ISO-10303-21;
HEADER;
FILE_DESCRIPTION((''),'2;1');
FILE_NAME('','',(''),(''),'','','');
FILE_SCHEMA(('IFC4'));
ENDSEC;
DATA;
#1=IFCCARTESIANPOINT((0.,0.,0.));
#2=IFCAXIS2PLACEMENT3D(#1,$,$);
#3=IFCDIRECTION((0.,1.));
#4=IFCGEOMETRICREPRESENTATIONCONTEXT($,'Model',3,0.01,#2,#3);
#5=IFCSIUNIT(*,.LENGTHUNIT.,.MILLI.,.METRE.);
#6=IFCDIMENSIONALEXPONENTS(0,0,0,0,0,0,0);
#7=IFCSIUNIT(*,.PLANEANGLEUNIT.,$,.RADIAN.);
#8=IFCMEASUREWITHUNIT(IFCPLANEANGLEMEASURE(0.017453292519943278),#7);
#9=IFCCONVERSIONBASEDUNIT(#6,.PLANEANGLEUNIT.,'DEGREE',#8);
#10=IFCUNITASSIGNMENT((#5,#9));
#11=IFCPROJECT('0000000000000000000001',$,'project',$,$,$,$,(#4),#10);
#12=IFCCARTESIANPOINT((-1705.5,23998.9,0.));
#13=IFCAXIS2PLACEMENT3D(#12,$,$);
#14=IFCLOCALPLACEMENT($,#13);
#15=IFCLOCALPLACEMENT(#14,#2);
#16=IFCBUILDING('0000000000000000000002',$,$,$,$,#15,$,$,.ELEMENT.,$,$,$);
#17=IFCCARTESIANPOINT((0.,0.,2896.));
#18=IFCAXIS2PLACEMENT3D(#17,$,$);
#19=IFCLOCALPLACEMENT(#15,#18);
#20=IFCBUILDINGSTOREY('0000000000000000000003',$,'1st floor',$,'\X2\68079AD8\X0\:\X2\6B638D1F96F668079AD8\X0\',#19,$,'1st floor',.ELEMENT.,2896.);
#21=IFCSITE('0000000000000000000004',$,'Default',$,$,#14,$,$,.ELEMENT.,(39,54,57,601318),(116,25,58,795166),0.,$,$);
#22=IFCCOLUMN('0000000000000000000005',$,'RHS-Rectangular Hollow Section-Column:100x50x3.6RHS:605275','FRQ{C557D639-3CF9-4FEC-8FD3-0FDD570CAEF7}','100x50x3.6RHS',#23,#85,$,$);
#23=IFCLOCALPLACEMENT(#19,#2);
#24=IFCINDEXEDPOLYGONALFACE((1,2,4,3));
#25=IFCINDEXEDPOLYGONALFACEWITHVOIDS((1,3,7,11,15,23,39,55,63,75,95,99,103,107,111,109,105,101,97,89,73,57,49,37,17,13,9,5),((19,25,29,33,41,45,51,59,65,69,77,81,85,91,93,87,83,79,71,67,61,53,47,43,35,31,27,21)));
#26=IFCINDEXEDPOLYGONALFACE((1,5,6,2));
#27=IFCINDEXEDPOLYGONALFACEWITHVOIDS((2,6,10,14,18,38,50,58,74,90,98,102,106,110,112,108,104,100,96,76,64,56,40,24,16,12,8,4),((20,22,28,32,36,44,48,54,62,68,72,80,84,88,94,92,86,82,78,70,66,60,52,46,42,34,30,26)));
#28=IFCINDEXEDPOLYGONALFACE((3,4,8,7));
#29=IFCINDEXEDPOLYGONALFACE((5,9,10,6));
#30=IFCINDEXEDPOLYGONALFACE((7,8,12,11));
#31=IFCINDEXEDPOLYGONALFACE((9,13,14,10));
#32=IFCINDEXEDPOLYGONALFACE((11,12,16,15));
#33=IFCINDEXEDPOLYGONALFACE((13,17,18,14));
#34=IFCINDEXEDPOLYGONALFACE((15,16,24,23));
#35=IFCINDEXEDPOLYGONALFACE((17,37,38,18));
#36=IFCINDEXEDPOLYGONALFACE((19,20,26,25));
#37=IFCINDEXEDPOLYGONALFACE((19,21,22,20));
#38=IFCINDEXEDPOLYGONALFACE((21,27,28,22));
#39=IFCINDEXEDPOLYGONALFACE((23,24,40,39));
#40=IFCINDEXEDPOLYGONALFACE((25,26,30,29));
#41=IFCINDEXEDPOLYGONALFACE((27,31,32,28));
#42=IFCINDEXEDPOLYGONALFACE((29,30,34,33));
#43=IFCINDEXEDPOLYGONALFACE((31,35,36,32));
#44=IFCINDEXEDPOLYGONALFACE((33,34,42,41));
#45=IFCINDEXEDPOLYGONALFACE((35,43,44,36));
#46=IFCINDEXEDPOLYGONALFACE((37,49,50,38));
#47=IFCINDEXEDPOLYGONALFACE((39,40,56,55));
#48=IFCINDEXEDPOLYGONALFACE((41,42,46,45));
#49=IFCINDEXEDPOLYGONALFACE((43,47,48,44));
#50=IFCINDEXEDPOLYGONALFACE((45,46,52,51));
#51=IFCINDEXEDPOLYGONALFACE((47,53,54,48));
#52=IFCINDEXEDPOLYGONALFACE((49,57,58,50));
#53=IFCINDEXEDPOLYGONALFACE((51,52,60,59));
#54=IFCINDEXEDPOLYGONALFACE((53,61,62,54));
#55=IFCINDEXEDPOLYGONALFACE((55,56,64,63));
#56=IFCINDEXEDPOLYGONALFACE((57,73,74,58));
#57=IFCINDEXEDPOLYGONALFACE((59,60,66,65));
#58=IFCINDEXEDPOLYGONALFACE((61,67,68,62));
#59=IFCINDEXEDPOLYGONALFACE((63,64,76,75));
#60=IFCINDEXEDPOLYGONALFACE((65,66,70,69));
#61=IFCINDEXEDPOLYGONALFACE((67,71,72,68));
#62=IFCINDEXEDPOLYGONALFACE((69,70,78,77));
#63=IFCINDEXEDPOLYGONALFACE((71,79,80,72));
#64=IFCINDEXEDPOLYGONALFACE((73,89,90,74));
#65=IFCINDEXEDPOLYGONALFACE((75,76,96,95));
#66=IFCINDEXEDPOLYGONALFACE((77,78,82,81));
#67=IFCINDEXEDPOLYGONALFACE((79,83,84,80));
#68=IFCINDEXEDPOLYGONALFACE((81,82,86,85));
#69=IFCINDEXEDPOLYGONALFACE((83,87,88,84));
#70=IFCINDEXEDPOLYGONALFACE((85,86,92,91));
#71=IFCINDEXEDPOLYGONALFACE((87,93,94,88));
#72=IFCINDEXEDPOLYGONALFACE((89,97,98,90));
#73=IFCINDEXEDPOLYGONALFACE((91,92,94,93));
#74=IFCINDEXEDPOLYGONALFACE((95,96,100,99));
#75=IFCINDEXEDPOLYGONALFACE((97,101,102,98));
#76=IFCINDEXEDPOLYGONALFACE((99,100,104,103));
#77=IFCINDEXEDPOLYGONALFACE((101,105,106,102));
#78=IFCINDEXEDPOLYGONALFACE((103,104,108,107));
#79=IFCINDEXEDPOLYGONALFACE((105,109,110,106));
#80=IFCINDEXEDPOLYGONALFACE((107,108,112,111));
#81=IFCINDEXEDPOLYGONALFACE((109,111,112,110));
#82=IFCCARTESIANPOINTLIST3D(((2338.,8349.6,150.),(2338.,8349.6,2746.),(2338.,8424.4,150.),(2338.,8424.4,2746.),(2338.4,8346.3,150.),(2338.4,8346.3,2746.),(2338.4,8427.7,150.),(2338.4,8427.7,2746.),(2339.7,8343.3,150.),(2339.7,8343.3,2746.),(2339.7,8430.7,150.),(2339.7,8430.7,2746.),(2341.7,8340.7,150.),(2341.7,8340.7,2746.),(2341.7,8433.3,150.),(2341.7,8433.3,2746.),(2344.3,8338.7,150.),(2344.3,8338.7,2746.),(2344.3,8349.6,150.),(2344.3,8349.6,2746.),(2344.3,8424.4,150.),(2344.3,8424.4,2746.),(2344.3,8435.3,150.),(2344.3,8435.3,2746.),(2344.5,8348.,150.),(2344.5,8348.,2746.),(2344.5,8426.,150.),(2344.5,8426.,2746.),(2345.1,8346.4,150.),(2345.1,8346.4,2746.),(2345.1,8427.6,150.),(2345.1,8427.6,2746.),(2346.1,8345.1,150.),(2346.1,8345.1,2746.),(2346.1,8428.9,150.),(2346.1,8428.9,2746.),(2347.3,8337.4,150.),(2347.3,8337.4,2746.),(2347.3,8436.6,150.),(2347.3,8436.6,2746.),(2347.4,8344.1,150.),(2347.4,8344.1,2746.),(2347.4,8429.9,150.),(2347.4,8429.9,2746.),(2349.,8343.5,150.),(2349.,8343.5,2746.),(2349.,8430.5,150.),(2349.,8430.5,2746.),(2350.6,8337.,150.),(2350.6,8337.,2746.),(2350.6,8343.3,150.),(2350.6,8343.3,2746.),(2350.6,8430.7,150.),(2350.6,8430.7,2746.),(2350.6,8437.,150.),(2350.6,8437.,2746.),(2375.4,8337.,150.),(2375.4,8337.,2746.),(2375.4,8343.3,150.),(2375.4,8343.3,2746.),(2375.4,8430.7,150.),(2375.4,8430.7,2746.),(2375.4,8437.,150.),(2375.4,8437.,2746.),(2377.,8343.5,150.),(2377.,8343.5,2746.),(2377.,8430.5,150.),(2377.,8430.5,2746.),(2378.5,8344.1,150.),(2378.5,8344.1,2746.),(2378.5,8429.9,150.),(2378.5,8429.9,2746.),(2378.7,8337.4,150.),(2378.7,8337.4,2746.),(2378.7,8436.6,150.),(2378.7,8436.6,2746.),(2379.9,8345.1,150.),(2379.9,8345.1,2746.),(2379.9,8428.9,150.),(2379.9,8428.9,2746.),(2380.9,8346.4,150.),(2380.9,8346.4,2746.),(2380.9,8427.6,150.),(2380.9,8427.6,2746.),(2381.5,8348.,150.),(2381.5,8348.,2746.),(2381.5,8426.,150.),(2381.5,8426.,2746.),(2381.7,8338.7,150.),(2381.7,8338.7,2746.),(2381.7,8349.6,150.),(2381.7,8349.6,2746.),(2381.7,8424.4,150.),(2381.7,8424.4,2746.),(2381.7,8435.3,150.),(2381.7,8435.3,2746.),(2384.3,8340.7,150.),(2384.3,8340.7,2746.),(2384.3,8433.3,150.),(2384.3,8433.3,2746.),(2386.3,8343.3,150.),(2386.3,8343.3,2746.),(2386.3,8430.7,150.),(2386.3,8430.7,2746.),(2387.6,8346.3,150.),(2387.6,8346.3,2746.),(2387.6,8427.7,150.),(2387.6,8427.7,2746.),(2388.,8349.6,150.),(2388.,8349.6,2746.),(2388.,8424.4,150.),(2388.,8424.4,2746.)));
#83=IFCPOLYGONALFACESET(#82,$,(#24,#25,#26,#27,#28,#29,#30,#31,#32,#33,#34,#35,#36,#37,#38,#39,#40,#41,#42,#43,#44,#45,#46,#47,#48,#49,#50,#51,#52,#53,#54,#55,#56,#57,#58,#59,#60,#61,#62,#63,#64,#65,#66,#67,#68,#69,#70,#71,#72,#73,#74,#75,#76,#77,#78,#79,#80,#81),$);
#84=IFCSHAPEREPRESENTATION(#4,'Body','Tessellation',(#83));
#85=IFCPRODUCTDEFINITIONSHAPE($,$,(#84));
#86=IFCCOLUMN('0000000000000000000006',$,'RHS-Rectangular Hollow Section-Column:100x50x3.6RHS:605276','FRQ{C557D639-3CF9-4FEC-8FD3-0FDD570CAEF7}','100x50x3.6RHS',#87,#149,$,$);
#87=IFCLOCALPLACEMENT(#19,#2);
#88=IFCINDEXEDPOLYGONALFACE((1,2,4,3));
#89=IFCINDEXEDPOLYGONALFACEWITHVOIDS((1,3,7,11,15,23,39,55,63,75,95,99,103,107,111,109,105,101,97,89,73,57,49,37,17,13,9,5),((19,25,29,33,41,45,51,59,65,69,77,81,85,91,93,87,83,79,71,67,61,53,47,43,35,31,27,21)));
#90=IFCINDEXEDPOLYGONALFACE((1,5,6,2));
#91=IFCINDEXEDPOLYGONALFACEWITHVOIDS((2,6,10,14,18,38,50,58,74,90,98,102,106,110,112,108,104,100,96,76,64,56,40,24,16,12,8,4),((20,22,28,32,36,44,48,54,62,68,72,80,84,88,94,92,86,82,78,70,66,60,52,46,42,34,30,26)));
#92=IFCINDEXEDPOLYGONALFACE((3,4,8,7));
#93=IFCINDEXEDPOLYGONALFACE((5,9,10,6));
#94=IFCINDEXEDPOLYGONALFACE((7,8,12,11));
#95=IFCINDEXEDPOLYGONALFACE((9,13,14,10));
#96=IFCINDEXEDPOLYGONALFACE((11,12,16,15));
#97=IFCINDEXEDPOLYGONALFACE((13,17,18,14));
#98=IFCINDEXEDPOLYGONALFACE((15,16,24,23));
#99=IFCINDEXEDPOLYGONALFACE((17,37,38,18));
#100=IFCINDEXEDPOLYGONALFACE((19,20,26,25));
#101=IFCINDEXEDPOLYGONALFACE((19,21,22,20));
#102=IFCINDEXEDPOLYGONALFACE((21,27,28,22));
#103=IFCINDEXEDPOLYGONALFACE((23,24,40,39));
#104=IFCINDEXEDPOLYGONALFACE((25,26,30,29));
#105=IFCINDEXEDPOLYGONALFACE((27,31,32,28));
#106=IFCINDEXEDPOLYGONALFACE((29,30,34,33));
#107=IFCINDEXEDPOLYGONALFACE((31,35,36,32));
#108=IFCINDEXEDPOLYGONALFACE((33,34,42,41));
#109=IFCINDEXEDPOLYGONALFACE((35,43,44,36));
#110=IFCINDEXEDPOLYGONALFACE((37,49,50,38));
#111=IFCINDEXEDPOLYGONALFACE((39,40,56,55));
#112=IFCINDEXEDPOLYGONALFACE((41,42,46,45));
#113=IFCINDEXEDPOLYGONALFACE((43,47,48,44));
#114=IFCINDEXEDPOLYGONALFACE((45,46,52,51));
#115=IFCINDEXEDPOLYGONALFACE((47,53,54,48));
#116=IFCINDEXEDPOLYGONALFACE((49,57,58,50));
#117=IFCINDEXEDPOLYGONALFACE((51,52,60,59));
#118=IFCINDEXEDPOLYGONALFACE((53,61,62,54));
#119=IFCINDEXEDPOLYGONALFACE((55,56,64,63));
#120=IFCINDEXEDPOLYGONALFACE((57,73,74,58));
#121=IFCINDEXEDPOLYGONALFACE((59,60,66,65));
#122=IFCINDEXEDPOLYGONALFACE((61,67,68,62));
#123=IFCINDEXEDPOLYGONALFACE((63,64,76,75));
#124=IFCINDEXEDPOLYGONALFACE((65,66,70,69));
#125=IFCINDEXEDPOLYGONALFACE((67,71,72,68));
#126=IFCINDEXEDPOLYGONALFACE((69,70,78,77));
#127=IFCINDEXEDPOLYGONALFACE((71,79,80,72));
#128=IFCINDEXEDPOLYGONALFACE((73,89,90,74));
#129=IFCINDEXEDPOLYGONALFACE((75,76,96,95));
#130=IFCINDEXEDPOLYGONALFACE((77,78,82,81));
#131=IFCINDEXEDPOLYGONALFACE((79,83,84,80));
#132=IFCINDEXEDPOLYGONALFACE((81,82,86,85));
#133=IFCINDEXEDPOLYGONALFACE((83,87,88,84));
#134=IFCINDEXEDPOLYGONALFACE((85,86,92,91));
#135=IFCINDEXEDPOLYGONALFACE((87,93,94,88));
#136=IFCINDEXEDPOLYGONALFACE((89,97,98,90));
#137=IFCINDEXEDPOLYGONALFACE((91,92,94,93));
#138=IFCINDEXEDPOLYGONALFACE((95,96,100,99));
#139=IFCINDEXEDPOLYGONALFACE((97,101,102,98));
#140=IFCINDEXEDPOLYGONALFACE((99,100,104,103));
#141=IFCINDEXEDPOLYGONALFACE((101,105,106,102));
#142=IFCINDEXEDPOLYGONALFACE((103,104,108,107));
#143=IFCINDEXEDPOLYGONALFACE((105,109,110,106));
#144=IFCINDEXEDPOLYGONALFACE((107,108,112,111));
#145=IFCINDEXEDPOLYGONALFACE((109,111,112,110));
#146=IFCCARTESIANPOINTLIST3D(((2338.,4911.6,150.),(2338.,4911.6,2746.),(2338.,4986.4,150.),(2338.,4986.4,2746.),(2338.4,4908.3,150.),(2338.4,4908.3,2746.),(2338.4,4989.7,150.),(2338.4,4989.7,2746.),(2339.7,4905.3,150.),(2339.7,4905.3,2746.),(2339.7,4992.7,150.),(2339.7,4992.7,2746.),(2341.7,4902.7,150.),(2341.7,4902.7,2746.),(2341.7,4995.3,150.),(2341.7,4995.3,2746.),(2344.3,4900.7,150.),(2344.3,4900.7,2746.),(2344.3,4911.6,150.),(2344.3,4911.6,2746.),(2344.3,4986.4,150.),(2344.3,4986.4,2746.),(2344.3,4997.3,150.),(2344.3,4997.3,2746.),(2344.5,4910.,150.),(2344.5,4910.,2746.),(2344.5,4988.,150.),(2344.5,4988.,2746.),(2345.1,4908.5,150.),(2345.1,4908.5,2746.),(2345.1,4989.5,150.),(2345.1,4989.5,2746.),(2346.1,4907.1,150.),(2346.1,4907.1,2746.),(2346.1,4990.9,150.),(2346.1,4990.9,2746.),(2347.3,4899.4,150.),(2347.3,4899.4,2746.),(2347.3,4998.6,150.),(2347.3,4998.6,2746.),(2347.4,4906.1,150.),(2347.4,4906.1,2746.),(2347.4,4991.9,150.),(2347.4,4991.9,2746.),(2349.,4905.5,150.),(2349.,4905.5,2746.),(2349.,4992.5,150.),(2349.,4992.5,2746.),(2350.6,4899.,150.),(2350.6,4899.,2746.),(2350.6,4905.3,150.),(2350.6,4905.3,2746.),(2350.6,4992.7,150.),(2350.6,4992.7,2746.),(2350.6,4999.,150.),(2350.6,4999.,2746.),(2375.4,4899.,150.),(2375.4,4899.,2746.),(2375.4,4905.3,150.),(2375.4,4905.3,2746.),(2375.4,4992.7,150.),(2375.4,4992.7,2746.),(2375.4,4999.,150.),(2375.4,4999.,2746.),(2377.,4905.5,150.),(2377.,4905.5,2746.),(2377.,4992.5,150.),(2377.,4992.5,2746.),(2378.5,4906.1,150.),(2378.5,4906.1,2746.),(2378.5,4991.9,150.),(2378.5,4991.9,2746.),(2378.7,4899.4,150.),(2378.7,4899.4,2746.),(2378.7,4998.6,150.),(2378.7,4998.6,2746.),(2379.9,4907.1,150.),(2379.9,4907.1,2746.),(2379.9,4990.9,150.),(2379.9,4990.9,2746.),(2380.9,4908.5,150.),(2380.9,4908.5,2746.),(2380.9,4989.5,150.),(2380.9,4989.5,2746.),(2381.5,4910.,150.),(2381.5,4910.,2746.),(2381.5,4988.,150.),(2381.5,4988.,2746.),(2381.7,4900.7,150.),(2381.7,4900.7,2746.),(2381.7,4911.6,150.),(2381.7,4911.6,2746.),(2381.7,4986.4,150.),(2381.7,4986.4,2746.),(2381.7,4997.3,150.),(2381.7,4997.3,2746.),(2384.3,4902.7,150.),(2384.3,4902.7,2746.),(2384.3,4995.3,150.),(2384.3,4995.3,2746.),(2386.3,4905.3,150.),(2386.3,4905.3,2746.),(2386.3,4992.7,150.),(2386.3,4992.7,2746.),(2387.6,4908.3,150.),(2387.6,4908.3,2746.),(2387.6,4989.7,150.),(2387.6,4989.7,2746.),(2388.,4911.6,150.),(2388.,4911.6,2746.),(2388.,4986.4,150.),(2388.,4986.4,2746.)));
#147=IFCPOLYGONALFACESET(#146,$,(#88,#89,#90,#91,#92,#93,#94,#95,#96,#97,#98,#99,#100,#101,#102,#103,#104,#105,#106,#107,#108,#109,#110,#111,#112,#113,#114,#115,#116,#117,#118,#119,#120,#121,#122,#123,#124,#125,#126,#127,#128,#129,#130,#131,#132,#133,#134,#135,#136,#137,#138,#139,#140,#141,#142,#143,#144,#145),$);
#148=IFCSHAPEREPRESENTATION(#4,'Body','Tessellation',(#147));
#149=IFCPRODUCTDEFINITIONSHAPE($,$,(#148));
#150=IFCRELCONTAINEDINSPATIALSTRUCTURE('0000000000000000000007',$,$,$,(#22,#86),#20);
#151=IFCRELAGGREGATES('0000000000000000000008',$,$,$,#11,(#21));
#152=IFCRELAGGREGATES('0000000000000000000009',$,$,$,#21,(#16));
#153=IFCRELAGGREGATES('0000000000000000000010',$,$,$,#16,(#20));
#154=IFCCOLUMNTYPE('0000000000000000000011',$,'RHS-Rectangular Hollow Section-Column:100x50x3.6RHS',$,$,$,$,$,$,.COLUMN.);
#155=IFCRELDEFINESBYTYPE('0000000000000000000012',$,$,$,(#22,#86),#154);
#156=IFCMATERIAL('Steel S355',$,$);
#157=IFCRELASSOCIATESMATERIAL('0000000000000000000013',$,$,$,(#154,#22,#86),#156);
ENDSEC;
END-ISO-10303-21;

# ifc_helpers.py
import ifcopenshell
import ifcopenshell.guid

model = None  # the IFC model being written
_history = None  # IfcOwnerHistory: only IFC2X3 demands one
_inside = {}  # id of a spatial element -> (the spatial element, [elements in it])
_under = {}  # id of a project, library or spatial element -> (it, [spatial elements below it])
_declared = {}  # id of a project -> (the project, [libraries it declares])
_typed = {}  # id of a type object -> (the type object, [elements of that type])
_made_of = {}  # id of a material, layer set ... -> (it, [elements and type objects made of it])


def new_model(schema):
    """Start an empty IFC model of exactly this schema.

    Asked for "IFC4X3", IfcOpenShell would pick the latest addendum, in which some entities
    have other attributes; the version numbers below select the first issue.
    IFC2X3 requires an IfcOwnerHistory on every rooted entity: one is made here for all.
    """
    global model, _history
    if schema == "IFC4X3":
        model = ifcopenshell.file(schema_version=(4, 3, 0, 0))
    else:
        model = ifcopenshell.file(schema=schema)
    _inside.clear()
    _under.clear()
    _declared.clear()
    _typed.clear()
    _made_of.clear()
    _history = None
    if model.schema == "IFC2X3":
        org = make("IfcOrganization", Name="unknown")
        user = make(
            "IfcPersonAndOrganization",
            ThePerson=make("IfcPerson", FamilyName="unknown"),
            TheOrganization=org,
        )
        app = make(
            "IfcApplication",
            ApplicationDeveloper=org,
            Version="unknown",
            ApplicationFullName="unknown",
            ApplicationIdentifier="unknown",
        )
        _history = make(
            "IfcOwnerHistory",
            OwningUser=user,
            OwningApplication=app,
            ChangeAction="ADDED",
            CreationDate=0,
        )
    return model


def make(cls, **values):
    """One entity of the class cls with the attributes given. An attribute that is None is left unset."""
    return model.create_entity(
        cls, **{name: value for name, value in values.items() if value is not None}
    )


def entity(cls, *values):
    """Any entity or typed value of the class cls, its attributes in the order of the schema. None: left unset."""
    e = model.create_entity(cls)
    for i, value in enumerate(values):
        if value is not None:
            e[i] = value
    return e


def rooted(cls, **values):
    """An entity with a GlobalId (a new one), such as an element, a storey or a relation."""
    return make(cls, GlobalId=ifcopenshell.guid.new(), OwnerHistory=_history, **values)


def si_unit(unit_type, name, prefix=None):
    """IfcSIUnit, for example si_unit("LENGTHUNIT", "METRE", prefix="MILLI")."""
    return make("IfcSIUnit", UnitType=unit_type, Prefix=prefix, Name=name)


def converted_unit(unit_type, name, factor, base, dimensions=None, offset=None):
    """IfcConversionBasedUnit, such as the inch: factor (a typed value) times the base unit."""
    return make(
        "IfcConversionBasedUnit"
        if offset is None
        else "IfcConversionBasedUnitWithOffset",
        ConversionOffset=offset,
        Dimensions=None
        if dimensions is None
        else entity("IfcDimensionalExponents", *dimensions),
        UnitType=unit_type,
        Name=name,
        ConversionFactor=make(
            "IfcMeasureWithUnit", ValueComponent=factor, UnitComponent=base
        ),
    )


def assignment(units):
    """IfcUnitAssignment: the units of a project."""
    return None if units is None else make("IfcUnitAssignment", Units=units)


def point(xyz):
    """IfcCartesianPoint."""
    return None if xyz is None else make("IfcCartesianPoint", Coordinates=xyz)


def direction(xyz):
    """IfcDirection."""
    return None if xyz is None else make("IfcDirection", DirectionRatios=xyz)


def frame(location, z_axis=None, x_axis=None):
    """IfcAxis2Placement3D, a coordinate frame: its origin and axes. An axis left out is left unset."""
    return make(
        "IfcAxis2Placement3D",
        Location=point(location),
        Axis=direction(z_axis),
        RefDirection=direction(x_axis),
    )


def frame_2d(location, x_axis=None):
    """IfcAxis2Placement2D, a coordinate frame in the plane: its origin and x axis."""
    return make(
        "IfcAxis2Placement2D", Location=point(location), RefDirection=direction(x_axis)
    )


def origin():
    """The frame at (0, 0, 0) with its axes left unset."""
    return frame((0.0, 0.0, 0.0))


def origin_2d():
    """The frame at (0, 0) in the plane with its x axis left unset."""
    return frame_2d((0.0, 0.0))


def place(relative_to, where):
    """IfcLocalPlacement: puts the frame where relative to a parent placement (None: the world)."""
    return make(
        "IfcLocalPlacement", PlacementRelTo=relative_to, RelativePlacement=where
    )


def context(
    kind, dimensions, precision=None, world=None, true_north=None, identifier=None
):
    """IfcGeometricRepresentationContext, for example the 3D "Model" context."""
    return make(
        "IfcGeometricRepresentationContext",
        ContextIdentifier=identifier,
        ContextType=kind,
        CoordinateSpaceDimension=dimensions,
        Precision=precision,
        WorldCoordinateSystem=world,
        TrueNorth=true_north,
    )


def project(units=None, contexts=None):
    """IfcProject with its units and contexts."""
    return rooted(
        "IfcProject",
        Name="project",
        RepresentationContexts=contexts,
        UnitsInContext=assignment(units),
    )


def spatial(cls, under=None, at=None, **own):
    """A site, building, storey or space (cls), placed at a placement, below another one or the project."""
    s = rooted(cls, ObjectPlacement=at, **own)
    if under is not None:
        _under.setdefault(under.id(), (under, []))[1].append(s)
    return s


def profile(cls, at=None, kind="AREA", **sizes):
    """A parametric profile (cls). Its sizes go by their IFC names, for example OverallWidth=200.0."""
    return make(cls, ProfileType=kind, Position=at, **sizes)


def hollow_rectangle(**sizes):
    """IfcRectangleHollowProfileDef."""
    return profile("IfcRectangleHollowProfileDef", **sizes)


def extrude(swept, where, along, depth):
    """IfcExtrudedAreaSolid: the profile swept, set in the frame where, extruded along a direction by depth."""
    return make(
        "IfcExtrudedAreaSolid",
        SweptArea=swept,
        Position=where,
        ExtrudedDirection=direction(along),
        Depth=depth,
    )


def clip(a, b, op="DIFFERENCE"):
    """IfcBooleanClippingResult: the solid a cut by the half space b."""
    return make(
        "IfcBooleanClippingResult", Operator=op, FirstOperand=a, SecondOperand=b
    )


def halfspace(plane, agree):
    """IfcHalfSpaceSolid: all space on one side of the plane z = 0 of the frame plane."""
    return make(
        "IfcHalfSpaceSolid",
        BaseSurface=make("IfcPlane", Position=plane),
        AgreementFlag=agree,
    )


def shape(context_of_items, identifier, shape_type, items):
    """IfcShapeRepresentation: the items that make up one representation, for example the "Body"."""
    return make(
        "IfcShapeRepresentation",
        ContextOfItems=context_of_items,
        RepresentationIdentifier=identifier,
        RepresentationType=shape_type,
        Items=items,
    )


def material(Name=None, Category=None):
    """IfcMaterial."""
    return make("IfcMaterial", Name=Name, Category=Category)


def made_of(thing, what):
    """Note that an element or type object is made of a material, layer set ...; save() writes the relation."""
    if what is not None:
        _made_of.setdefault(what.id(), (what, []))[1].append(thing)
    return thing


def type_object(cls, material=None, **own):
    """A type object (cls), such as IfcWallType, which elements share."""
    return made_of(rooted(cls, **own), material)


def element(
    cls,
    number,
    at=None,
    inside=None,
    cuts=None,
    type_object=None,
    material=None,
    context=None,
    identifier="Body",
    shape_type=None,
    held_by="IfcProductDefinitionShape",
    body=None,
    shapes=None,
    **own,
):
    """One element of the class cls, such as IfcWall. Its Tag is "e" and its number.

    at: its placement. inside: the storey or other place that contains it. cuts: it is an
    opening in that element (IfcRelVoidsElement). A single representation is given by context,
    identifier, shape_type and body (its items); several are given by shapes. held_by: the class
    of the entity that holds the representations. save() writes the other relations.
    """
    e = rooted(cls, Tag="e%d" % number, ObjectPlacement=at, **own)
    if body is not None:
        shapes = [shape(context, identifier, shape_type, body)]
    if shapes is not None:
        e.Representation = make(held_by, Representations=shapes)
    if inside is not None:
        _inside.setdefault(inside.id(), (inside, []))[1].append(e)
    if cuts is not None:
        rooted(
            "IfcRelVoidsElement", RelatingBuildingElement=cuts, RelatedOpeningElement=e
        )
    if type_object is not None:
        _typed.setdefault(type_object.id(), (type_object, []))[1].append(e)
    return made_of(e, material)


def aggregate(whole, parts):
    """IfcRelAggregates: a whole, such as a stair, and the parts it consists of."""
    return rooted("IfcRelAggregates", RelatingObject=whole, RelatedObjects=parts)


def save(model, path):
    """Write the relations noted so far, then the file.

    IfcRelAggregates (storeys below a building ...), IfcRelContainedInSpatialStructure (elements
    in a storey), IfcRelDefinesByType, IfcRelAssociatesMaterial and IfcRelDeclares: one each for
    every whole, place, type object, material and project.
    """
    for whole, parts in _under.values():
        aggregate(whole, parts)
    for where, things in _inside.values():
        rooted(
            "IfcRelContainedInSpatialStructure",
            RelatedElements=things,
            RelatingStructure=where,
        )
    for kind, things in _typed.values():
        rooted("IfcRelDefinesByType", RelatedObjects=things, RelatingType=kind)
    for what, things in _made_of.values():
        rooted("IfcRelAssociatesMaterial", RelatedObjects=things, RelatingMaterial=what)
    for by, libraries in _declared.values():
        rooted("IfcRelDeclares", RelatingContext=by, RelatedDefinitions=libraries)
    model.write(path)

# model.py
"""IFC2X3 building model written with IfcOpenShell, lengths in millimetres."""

from ifc_helpers import new_model, entity, si_unit, converted_unit, direction, frame, origin, origin_2d, place, context, project, spatial, hollow_rectangle, extrude, clip, halfspace, material, type_object, element, save


model = new_model("IFC2X3")

# Units and contexts
model_context = context("Model", 3, precision=0.01, world=origin(), true_north=direction((0.0, 1.0)))
ifc_project = project(units=[si_unit("LENGTHUNIT", "METRE", prefix="MILLI"), converted_unit("PLANEANGLEUNIT", "DEGREE", entity("IfcPlaneAngleMeasure", 0.017453292519943278), si_unit("PLANEANGLEUNIT", "RADIAN"), dimensions=[0, 0, 0, 0, 0, 0, 0])], contexts=[model_context])

# Site, building, storey
site_placement = place(None, frame((-1705.5, 23998.9, 0.0)))
site = spatial("IfcSite", under=ifc_project, at=site_placement, Name="Default", CompositionType="ELEMENT", RefLatitude=(39, 54, 57, 601318), RefLongitude=(116, 25, 58, 795166), RefElevation=0.0)
building_placement = place(site_placement, origin())
building = spatial("IfcBuilding", under=site, at=building_placement, CompositionType="ELEMENT")
storey_placement = place(building_placement, frame((0.0, 0.0, 2896.0)))
storey = spatial("IfcBuildingStorey", under=building, at=storey_placement, Name="1st floor", ObjectType="标高:正负零标高", LongName="1st floor", CompositionType="ELEMENT", Elevation=2896.0)

# Shared definitions
ifc_material_1 = material(Name="Steel S355")

# Columns
column_type_1 = type_object("IfcColumnType", Name="RHS-Rectangular Hollow Section-Column:100x50x3.6RHS", PredefinedType="COLUMN", material=ifc_material_1)
column_1_placement = place(storey_placement, frame((2363.0, 8387.0, 2746.0), z_axis=(0.0, 0.0, 1.0), x_axis=(-1.0, 0.0, 0.0)))
element("IfcColumn", 1, at=column_1_placement, inside=storey, type_object=column_type_1, material=ifc_material_1, Name="RHS-Rectangular Hollow Section-Column:100x50x3.6RHS:605275", Description="FRQ{C557D639-3CF9-4FEC-8FD3-0FDD570CAEF7}", ObjectType="100x50x3.6RHS", context=model_context, shape_type="Clipping", body=[
    clip(extrude(hollow_rectangle(XDim=50.0, YDim=100.0, WallThickness=6.3, InnerFilletRadius=6.3, OuterFilletRadius=12.6, at=origin_2d()), origin(), (0.0, 0.0, -1.0), 2651.9), halfspace(frame((2363.0, 8387.0, -2596.0), z_axis=(0.0, 0.0, 1.0), x_axis=(-1.0, 0.0, 0.0)), True)),
])
column_2_placement = place(storey_placement, frame((2363.0, 4949.0, 2746.0), z_axis=(0.0, 0.0, 1.0), x_axis=(-1.0, 0.0, 0.0)))
element("IfcColumn", 2, at=column_2_placement, inside=storey, type_object=column_type_1, material=ifc_material_1, Name="RHS-Rectangular Hollow Section-Column:100x50x3.6RHS:605276", Description="FRQ{C557D639-3CF9-4FEC-8FD3-0FDD570CAEF7}", ObjectType="100x50x3.6RHS", context=model_context, shape_type="Clipping", body=[
    clip(extrude(hollow_rectangle(XDim=50.0, YDim=100.0, WallThickness=6.3, InnerFilletRadius=6.3, OuterFilletRadius=12.6, at=origin_2d()), origin(), (0.0, 0.0, -1.0), 2651.9), halfspace(frame((2363.0, 4949.0, -2596.0), z_axis=(0.0, 0.0, 1.0), x_axis=(-1.0, 0.0, 0.0)), True)),
])

save(model, "model.ifc")
